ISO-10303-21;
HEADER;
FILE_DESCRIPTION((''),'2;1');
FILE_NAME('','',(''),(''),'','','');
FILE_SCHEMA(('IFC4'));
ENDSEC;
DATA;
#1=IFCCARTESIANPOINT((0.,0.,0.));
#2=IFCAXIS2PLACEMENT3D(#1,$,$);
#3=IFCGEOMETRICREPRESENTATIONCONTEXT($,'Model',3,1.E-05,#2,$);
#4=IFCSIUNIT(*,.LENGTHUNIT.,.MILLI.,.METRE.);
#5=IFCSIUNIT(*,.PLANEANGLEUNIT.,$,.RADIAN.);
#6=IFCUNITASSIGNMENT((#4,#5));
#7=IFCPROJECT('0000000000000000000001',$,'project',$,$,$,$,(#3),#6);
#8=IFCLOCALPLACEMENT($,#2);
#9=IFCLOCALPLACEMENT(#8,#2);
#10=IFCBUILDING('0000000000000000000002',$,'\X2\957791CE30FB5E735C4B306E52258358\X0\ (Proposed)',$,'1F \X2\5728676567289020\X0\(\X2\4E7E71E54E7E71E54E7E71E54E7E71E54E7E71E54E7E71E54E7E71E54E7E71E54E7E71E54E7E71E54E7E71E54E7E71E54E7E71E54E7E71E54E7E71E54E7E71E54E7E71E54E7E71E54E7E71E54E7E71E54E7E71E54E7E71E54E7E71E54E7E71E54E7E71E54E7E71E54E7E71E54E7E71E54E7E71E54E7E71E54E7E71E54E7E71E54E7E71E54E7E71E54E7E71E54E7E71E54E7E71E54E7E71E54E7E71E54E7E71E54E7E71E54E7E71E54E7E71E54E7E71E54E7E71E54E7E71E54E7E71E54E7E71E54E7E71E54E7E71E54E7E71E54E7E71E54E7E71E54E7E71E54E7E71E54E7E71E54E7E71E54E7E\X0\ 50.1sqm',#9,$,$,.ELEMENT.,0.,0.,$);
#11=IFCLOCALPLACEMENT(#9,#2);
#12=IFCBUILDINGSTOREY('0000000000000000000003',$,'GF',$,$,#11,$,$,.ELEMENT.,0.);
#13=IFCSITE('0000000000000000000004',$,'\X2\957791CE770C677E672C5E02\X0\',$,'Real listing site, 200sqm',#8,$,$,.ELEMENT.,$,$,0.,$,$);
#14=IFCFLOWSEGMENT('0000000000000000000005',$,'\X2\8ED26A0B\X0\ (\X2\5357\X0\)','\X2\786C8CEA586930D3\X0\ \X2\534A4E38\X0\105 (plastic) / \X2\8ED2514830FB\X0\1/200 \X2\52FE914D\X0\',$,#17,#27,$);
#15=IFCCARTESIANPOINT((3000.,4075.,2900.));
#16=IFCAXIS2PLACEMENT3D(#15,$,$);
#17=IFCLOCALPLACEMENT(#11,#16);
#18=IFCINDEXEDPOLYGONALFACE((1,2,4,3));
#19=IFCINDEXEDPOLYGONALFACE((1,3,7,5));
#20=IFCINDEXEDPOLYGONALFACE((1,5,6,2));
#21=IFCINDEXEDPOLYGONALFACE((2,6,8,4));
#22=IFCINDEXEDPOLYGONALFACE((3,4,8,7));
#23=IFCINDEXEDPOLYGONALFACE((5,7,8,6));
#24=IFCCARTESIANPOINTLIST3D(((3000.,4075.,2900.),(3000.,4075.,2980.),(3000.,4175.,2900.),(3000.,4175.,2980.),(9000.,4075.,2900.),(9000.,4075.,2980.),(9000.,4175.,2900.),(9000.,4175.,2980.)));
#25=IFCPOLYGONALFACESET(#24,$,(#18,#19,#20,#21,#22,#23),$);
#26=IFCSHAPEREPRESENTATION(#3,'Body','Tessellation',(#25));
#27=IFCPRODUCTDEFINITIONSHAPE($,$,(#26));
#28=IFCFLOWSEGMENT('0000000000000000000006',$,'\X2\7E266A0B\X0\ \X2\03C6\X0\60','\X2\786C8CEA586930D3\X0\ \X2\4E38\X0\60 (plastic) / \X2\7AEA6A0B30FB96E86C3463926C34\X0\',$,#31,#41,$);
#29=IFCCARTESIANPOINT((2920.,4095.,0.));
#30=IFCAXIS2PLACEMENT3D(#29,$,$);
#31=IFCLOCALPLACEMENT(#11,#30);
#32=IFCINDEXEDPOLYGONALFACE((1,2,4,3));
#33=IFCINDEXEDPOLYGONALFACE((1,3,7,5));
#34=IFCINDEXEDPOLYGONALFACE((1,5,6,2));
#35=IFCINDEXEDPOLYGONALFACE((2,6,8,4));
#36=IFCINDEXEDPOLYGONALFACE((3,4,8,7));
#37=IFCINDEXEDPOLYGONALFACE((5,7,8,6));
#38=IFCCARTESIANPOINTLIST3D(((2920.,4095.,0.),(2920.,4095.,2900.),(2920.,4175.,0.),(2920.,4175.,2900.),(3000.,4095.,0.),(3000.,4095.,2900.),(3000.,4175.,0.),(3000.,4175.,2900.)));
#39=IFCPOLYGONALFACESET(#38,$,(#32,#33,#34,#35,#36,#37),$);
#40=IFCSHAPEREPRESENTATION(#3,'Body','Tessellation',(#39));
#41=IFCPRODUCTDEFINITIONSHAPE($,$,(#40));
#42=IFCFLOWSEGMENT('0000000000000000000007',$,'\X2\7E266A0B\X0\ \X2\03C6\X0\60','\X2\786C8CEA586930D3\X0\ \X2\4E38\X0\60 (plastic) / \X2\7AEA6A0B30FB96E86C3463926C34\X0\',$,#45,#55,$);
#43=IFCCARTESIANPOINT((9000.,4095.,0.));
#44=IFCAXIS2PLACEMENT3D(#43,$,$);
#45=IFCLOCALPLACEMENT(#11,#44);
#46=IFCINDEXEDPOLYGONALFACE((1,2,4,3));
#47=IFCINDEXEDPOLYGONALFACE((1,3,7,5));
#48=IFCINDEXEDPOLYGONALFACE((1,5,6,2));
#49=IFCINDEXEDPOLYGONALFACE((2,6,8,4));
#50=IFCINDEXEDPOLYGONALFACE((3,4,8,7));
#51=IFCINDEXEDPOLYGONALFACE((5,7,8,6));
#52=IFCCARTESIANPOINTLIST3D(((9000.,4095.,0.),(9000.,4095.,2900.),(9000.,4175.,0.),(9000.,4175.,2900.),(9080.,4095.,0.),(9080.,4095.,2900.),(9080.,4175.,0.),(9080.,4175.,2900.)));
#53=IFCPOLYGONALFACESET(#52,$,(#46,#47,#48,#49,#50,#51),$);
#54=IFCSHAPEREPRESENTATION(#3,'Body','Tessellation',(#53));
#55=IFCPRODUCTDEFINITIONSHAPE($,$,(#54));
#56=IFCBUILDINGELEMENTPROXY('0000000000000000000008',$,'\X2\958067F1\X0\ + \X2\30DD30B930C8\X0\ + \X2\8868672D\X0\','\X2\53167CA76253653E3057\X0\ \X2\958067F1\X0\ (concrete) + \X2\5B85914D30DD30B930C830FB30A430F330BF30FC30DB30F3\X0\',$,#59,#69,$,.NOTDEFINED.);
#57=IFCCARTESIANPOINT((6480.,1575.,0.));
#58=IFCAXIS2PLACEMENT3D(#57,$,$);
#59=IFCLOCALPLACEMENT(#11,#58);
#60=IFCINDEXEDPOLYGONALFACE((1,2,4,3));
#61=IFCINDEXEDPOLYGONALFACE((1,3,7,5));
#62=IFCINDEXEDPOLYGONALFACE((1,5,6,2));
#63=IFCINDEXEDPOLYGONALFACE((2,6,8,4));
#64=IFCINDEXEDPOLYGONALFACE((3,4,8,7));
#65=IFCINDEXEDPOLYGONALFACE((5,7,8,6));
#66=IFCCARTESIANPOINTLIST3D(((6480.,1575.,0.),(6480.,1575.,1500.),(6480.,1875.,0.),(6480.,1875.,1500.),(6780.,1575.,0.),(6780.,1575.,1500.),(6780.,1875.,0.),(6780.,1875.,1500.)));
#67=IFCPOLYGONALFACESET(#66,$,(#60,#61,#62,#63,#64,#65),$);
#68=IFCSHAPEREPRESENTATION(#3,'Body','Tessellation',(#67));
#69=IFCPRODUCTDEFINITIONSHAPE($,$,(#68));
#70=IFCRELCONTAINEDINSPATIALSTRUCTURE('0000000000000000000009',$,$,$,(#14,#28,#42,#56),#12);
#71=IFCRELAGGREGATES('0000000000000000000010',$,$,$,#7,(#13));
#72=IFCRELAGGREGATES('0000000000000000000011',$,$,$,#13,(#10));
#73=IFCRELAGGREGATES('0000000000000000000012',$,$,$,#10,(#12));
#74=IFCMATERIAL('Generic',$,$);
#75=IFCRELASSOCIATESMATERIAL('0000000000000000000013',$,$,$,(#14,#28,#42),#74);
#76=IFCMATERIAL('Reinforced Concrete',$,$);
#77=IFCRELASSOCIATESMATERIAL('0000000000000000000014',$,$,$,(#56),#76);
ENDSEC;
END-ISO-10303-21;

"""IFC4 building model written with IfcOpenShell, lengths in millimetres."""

from ifc_helpers import new_model, si_unit, frame, frame_2d, origin, place, context, project, spatial, rectangle, extrude, material, element, save


model = new_model("IFC4")

# Units and contexts
model_context = context("Model", 3, precision=1e-05, world=origin())
ifc_project = project(units=[si_unit("LENGTHUNIT", "METRE", prefix="MILLI"), si_unit("PLANEANGLEUNIT", "RADIAN")], contexts=[model_context])

# Site, building, storey
site_placement = place(None, origin())
site = spatial("IfcSite", under=ifc_project, at=site_placement, Name="長野県松本市", ObjectType="Real listing site, 200sqm", CompositionType="ELEMENT", RefElevation=0.0)
building_placement = place(site_placement, origin())
building = spatial("IfcBuilding", under=site, at=building_placement, Name="長野・平屋の別荘 (Proposed)", ObjectType="1F 在来木造(乾燥乾燥乾燥乾燥乾燥乾燥乾燥乾燥乾燥乾燥乾燥乾燥乾燥乾燥乾燥乾燥乾燥乾燥乾燥乾燥乾燥乾燥乾燥乾燥乾燥乾燥乾燥乾燥乾燥乾燥乾燥乾燥乾燥乾燥乾燥乾燥乾燥乾燥乾燥乾燥乾燥乾燥乾燥乾燥乾燥乾燥乾燥乾燥乾燥乾燥乾燥乾燥乾燥乾燥乾燥乾燥乾燥乾 50.1sqm", CompositionType="ELEMENT", ElevationOfRefHeight=0.0, ElevationOfTerrain=0.0)
storey_placement = place(building_placement, origin())
storey = spatial("IfcBuildingStorey", under=building, at=storey_placement, Name="GF", CompositionType="ELEMENT", Elevation=0.0)

# Shared definitions
ifc_material_1 = material(Name="Reinforced Concrete")

# Flow segments
ifc_material_2 = material(Name="Generic")
flow_segment_1_placement = place(storey_placement, frame((3000.0, 4075.0, 2900.0)))
element("IfcFlowSegment", 1, at=flow_segment_1_placement, inside=storey, material=ifc_material_2, Name="軒樋 (南)", Description="硬質塩ビ 半丸105 (plastic) / 軒先・1/200 勾配", context=model_context, shape_type="SweptSolid", body=[
    extrude(rectangle(XDim=6000.0, YDim=100.0, at=frame_2d((3000.0, 50.0))), frame((3000.0, 4075.0, 2900.0)), (0.0, 0.0, 1.0), 80.0),
])
flow_segment_2_placement = place(storey_placement, frame((2920.0, 4095.0, 0.0)))
element("IfcFlowSegment", 2, at=flow_segment_2_placement, inside=storey, material=ifc_material_2, Name="縦樋 φ60", Description="硬質塩ビ 丸60 (plastic) / 竪樋・雨水排水", context=model_context, shape_type="SweptSolid", body=[
    extrude(rectangle(XDim=80.0, YDim=80.0, at=frame_2d((40.0, 40.0))), frame((2920.0, 4095.0, 0.0)), (0.0, 0.0, 1.0), 2900.0),
])
flow_segment_3_placement = place(storey_placement, frame((9000.0, 4095.0, 0.0)))
element("IfcFlowSegment", 3, at=flow_segment_3_placement, inside=storey, material=ifc_material_2, Name="縦樋 φ60", Description="硬質塩ビ 丸60 (plastic) / 竪樋・雨水排水", context=model_context, shape_type="SweptSolid", body=[
    extrude(rectangle(XDim=80.0, YDim=80.0, at=frame_2d((40.0, 40.0))), frame((9000.0, 4095.0, 0.0)), (0.0, 0.0, 1.0), 2900.0),
])

# Building element proxy
proxy_placement = place(storey_placement, frame((6480.0, 1575.0, 0.0)))
element("IfcBuildingElementProxy", 4, at=proxy_placement, inside=storey, material=ifc_material_1, Name="門柱 + ポスト + 表札", Description="化粧打放し 門柱 (concrete) + 宅配ポスト・インターホン", PredefinedType="NOTDEFINED", context=model_context, shape_type="SweptSolid", body=[
    extrude(rectangle(XDim=300.0, YDim=300.0, at=frame_2d((150.0, 150.0))), frame((6480.0, 1575.0, 0.0)), (0.0, 0.0, 1.0), 1500.0),
])

save(model, "model.ifc")
